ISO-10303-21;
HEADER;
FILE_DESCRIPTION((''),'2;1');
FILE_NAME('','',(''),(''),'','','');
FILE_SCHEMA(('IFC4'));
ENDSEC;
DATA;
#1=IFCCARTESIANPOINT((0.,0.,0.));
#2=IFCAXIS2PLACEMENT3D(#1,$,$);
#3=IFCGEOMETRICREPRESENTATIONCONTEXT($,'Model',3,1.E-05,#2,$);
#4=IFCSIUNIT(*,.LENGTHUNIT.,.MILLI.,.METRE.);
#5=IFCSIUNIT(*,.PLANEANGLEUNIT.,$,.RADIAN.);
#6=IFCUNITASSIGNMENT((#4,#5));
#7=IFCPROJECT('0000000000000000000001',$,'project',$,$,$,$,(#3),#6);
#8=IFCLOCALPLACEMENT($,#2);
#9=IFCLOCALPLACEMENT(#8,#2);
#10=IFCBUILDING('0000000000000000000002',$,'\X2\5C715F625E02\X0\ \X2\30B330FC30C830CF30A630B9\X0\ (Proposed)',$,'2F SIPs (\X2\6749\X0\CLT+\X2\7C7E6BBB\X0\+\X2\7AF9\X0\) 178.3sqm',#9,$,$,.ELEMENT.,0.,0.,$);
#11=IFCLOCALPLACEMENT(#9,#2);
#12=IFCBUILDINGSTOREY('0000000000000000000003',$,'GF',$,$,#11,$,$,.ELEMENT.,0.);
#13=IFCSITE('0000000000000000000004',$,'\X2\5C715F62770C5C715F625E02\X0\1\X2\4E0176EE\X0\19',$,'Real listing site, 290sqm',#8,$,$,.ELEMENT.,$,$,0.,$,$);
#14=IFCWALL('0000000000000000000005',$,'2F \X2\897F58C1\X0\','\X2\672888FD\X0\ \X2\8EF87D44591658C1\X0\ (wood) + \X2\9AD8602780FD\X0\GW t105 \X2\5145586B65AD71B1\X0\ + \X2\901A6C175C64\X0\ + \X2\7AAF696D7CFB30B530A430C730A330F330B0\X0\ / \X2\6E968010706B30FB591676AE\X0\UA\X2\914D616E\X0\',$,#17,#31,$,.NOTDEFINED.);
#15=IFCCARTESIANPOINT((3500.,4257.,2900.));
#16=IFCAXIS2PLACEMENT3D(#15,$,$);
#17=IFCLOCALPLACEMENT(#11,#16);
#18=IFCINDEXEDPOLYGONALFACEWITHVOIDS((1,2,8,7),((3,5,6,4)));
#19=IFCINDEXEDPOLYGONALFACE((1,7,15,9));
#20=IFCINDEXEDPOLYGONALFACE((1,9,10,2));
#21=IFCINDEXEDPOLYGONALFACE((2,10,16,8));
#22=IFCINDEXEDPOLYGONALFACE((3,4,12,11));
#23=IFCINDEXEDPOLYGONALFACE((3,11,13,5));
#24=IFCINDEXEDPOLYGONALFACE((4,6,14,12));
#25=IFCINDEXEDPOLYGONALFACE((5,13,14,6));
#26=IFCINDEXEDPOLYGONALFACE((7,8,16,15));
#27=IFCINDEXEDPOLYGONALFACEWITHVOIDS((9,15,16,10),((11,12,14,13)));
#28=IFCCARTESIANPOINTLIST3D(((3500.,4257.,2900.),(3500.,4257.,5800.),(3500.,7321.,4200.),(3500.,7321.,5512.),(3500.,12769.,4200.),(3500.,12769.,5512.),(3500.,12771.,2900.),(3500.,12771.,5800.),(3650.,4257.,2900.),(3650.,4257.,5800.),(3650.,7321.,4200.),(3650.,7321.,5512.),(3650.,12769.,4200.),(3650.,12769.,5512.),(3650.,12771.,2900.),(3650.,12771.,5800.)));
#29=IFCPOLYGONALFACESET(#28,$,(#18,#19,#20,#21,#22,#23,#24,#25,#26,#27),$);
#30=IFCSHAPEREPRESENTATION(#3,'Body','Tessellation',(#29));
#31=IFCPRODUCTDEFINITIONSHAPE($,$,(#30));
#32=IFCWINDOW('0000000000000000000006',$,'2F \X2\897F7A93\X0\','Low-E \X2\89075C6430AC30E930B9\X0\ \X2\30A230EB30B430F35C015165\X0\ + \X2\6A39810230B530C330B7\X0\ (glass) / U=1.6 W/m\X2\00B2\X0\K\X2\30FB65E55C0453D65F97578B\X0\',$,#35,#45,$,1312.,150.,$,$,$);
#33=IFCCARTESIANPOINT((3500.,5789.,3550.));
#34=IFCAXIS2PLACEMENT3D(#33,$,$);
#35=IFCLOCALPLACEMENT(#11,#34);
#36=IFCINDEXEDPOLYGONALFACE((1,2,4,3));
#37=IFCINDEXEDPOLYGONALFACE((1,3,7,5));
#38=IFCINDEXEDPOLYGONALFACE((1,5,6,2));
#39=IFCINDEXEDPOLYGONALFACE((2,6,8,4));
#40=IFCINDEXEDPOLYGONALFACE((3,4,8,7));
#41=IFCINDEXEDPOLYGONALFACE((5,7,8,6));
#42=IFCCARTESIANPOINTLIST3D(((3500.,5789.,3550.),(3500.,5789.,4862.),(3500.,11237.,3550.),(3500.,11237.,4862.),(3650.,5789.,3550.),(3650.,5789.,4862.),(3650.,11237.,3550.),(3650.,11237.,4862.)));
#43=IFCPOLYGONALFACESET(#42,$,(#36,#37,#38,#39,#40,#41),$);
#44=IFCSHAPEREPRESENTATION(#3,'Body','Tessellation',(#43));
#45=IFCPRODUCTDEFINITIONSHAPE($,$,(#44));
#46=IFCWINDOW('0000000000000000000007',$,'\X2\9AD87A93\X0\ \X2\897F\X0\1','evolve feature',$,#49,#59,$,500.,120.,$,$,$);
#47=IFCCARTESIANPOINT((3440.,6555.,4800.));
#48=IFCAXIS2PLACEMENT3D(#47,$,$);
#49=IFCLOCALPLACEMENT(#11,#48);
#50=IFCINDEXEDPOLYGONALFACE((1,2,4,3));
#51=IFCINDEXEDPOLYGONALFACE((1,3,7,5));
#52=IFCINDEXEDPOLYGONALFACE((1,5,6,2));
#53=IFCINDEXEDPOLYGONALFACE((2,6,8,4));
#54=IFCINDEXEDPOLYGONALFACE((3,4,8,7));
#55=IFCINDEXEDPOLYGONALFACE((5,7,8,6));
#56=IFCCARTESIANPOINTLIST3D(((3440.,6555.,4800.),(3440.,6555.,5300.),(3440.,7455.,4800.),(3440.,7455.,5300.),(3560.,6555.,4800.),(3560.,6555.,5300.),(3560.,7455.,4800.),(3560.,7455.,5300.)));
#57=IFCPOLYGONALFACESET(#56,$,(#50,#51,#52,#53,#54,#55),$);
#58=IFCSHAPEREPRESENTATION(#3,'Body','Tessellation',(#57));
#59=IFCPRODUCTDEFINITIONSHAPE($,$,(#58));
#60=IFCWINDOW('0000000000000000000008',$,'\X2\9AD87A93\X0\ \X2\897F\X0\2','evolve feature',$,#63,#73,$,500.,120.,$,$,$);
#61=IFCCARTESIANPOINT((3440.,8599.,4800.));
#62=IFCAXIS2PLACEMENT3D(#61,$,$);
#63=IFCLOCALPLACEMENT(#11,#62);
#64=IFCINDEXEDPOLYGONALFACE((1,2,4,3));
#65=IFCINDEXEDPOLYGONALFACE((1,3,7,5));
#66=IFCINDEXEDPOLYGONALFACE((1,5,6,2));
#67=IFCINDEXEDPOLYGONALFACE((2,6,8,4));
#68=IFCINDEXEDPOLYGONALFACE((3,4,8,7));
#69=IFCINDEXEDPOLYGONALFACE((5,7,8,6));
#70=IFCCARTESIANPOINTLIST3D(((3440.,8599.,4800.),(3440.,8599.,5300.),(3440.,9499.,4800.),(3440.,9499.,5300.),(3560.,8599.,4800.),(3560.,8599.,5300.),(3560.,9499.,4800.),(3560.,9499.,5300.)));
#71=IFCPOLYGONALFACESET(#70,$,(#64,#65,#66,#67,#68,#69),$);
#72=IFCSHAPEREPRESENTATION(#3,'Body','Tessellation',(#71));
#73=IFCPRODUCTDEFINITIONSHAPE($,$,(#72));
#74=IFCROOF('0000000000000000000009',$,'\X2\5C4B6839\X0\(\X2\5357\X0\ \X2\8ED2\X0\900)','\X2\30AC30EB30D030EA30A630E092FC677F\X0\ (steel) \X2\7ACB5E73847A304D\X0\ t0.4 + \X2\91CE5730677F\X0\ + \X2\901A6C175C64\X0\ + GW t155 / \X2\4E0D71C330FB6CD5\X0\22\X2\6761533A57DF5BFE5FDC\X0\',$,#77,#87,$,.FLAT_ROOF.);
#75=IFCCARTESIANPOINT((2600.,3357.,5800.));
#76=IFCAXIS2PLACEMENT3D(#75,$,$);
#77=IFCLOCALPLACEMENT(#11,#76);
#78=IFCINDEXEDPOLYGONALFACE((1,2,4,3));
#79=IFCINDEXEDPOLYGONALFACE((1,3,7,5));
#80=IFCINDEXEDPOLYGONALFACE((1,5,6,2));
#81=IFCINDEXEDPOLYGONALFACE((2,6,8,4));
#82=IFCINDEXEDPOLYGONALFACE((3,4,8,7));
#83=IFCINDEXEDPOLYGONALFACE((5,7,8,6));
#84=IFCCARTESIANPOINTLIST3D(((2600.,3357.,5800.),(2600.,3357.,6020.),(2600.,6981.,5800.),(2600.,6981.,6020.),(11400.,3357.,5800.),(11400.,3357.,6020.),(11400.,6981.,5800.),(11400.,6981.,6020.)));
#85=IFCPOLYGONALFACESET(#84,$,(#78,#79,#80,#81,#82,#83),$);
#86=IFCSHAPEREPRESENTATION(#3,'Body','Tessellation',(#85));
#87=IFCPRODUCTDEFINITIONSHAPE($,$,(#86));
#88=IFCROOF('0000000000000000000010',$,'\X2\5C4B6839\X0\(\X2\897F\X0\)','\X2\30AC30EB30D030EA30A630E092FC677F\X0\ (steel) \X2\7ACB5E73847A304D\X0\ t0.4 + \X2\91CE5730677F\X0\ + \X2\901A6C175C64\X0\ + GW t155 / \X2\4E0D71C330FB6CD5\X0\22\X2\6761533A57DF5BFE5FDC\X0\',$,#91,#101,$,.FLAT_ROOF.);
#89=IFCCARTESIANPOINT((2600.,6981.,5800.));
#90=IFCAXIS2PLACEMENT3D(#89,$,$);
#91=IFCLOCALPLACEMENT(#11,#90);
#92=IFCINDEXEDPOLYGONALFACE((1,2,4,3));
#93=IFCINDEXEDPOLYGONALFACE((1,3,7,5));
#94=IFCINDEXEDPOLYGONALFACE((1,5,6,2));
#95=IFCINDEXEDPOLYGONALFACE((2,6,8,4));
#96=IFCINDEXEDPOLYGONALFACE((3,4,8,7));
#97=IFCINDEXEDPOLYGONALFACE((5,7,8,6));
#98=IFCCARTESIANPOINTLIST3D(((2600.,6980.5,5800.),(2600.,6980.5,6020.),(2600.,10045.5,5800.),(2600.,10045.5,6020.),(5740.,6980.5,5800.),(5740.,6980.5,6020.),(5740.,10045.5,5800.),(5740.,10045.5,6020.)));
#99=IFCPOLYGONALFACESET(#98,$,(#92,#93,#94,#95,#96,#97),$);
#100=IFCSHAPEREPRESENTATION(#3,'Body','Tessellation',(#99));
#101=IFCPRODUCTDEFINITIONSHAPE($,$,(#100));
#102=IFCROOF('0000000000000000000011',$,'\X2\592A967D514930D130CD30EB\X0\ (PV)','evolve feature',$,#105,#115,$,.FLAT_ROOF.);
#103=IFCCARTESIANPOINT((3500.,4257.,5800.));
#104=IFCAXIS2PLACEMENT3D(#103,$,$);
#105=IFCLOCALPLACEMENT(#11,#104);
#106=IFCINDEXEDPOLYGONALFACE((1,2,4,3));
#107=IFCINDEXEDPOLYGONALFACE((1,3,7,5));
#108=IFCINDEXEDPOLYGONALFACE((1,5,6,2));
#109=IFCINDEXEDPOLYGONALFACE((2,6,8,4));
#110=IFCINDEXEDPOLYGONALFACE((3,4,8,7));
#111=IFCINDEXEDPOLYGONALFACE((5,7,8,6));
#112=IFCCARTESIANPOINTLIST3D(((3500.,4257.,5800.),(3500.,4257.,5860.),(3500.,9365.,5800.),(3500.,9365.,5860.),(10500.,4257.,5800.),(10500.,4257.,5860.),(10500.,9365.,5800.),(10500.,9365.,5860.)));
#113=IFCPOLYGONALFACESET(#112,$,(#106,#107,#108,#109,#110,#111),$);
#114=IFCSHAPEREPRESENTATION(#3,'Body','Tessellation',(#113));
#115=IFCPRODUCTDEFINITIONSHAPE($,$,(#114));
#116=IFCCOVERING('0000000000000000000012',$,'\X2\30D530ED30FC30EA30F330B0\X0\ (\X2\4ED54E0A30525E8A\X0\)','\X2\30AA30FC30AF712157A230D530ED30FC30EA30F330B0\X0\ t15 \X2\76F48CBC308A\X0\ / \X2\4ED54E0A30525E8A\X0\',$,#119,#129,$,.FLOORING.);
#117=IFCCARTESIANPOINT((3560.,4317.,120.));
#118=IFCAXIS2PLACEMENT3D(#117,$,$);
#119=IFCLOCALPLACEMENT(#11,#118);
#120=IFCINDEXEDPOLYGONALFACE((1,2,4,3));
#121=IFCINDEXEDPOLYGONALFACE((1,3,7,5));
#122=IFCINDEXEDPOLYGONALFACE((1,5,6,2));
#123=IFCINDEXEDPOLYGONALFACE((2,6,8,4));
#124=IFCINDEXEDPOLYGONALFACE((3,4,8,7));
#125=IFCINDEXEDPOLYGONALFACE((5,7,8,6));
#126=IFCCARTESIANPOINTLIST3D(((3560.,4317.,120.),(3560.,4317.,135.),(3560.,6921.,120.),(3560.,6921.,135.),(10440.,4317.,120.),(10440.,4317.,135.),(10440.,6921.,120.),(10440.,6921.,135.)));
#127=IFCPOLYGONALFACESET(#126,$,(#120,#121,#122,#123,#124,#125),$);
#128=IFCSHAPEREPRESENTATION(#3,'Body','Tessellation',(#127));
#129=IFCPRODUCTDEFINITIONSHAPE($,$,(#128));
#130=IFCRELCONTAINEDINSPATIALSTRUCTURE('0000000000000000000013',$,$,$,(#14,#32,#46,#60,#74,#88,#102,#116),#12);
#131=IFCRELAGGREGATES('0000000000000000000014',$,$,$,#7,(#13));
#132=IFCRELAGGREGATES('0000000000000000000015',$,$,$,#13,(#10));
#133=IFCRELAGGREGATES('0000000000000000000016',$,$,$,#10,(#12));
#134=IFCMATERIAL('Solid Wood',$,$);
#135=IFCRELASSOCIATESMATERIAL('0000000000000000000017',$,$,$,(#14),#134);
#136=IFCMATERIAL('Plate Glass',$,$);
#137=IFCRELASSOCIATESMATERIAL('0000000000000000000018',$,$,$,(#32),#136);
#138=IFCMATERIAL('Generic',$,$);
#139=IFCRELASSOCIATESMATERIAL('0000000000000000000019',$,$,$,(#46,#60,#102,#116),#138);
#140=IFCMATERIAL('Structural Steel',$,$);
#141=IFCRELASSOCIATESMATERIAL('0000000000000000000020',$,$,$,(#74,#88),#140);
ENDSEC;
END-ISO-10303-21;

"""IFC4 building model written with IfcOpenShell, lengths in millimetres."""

from ifc_helpers import new_model, si_unit, frame, frame_2d, origin, place, context, project, spatial, rectangle, extrude, material, element, fill, save


model = new_model("IFC4")

# Units and contexts
model_context = context("Model", 3, precision=1e-05, world=origin())
ifc_project = project(units=[si_unit("LENGTHUNIT", "METRE", prefix="MILLI"), si_unit("PLANEANGLEUNIT", "RADIAN")], contexts=[model_context])

# Site, building, storey
site_placement = place(None, origin())
site = spatial("IfcSite", under=ifc_project, at=site_placement, Name="山形県山形市1丁目19", ObjectType="Real listing site, 290sqm", CompositionType="ELEMENT", RefElevation=0.0)
building_placement = place(site_placement, origin())
building = spatial("IfcBuilding", under=site, at=building_placement, Name="山形市 コートハウス (Proposed)", ObjectType="2F SIPs (杉CLT+籾殻+竹) 178.3sqm", CompositionType="ELEMENT", ElevationOfRefHeight=0.0, ElevationOfTerrain=0.0)
storey_placement = place(building_placement, origin())
storey = spatial("IfcBuildingStorey", under=building, at=storey_placement, Name="GF", CompositionType="ELEMENT", Elevation=0.0)

# Shared definitions
ifc_material_1 = material(Name="Solid Wood")
ifc_material_2 = material(Name="Generic")

# Shared definitions
ifc_material_3 = material(Name="Plate Glass")

# Wall, openings, windows
wall_1_placement = place(storey_placement, frame((3500.0, 4257.0, 2900.0)))
wall_1 = element("IfcWall", 1, at=wall_1_placement, inside=storey, material=ifc_material_1, Name="2F 西壁", Description="木製 軸組外壁 (wood) + 高性能GW t105 充填断熱 + 通気層 + 窯業系サイディング / 準耐火・外皮UA配慮", PredefinedType="NOTDEFINED", context=model_context, shape_type="SweptSolid", body=[
    extrude(rectangle(XDim=150.0, YDim=8514.0, at=frame_2d((75.0, 4257.0))), frame((3500.0, 4257.0, 2900.0)), (0.0, 0.0, 1.0), 2900.0),
])
opening_1_placement = place(storey_placement, frame((3500.0, 5789.0, 3550.0)))
opening_1 = element("IfcOpeningElement", 2, at=opening_1_placement, cuts=wall_1, PredefinedType="NOTDEFINED", context=model_context, shape_type="SweptSolid", body=[
    extrude(rectangle(XDim=150.0, YDim=5448.0, at=frame_2d((75.0, 2724.0))), frame((3500.0, 5789.0, 3550.0)), (0.0, 0.0, 1.0), 1312.0),
])
opening_2_placement = place(storey_placement, frame((3440.0, 6555.0, 4800.0)))
opening_2 = element("IfcOpeningElement", 3, at=opening_2_placement, cuts=wall_1, PredefinedType="NOTDEFINED", context=model_context, shape_type="SweptSolid", body=[
    extrude(rectangle(XDim=120.0, YDim=900.0, at=frame_2d((60.0, 450.0))), frame((3440.0, 6555.0, 4800.0)), (0.0, 0.0, 1.0), 500.0),
])
opening_3_placement = place(storey_placement, frame((3440.0, 8599.0, 4800.0)))
opening_3 = element("IfcOpeningElement", 4, at=opening_3_placement, cuts=wall_1, PredefinedType="NOTDEFINED", context=model_context, shape_type="SweptSolid", body=[
    extrude(rectangle(XDim=120.0, YDim=900.0, at=frame_2d((60.0, 450.0))), frame((3440.0, 8599.0, 4800.0)), (0.0, 0.0, 1.0), 500.0),
])
window_1_placement = place(storey_placement, frame((3500.0, 5789.0, 3550.0)))
window_1 = element("IfcWindow", 5, at=window_1_placement, inside=storey, material=ifc_material_3, Name="2F 西窓", Description="Low-E 複層ガラス アルゴン封入 + 樹脂サッシ (glass) / U=1.6 W/m²K・日射取得型", OverallHeight=1312.0, OverallWidth=150.0, context=model_context, shape_type="SweptSolid", body=[
    extrude(rectangle(XDim=150.0, YDim=5448.0, at=frame_2d((75.0, 2724.0))), frame((3500.0, 5789.0, 3550.0)), (0.0, 0.0, 1.0), 1312.0),
])
fill(opening_1, window_1)
window_2_placement = place(storey_placement, frame((3440.0, 6555.0, 4800.0)))
window_2 = element("IfcWindow", 6, at=window_2_placement, inside=storey, material=ifc_material_2, Name="高窓 西1", Description="evolve feature", OverallHeight=500.0, OverallWidth=120.0, context=model_context, shape_type="SweptSolid", body=[
    extrude(rectangle(XDim=120.0, YDim=900.0, at=frame_2d((60.0, 450.0))), frame((3440.0, 6555.0, 4800.0)), (0.0, 0.0, 1.0), 500.0),
])
fill(opening_2, window_2)
window_3_placement = place(storey_placement, frame((3440.0, 8599.0, 4800.0)))
window_3 = element("IfcWindow", 7, at=window_3_placement, inside=storey, material=ifc_material_2, Name="高窓 西2", Description="evolve feature", OverallHeight=500.0, OverallWidth=120.0, context=model_context, shape_type="SweptSolid", body=[
    extrude(rectangle(XDim=120.0, YDim=900.0, at=frame_2d((60.0, 450.0))), frame((3440.0, 8599.0, 4800.0)), (0.0, 0.0, 1.0), 500.0),
])
fill(opening_3, window_3)

# Roofs
ifc_material_4 = material(Name="Structural Steel")
roof_1_placement = place(storey_placement, frame((2600.0, 3357.0, 5800.0)))
element("IfcRoof", 8, at=roof_1_placement, inside=storey, material=ifc_material_4, Name="屋根(南 軒900)", Description="ガルバリウム鋼板 (steel) 立平葺き t0.4 + 野地板 + 通気層 + GW t155 / 不燃・法22条区域対応", PredefinedType="FLAT_ROOF", context=model_context, shape_type="SweptSolid", body=[
    extrude(rectangle(XDim=8800.0, YDim=3624.0, at=frame_2d((4400.0, 1812.0))), frame((2600.0, 3357.0, 5800.0)), (0.0, 0.0, 1.0), 220.0),
])
roof_2_placement = place(storey_placement, frame((2600.0, 6981.0, 5800.0)))
element("IfcRoof", 9, at=roof_2_placement, inside=storey, material=ifc_material_4, Name="屋根(西)", Description="ガルバリウム鋼板 (steel) 立平葺き t0.4 + 野地板 + 通気層 + GW t155 / 不燃・法22条区域対応", PredefinedType="FLAT_ROOF", context=model_context, shape_type="SweptSolid", body=[
    extrude(rectangle(XDim=3140.0, YDim=3065.0, at=frame_2d((1570.0, 1532.0))), frame((2600.0, 6981.0, 5800.0)), (0.0, 0.0, 1.0), 220.0),
])
roof_3_placement = place(storey_placement, frame((3500.0, 4257.0, 5800.0)))
element("IfcRoof", 10, at=roof_3_placement, inside=storey, material=ifc_material_2, Name="太陽光パネル (PV)", Description="evolve feature", PredefinedType="FLAT_ROOF", context=model_context, shape_type="SweptSolid", body=[
    extrude(rectangle(XDim=7000.0, YDim=5108.0, at=frame_2d((3500.0, 2554.0))), frame((3500.0, 4257.0, 5800.0)), (0.0, 0.0, 1.0), 60.0),
])

# Covering
covering_placement = place(storey_placement, frame((3560.0, 4317.0, 120.0)))
element("IfcCovering", 11, at=covering_placement, inside=storey, material=ifc_material_2, Name="フローリング (仕上げ床)", Description="オーク無垢フローリング t15 直貼り / 仕上げ床", PredefinedType="FLOORING", context=model_context, shape_type="SweptSolid", body=[
    extrude(rectangle(XDim=6880.0, YDim=2604.0, at=frame_2d((3440.0, 1302.0))), frame((3560.0, 4317.0, 120.0)), (0.0, 0.0, 1.0), 15.0),
])

save(model, "model.ifc")
